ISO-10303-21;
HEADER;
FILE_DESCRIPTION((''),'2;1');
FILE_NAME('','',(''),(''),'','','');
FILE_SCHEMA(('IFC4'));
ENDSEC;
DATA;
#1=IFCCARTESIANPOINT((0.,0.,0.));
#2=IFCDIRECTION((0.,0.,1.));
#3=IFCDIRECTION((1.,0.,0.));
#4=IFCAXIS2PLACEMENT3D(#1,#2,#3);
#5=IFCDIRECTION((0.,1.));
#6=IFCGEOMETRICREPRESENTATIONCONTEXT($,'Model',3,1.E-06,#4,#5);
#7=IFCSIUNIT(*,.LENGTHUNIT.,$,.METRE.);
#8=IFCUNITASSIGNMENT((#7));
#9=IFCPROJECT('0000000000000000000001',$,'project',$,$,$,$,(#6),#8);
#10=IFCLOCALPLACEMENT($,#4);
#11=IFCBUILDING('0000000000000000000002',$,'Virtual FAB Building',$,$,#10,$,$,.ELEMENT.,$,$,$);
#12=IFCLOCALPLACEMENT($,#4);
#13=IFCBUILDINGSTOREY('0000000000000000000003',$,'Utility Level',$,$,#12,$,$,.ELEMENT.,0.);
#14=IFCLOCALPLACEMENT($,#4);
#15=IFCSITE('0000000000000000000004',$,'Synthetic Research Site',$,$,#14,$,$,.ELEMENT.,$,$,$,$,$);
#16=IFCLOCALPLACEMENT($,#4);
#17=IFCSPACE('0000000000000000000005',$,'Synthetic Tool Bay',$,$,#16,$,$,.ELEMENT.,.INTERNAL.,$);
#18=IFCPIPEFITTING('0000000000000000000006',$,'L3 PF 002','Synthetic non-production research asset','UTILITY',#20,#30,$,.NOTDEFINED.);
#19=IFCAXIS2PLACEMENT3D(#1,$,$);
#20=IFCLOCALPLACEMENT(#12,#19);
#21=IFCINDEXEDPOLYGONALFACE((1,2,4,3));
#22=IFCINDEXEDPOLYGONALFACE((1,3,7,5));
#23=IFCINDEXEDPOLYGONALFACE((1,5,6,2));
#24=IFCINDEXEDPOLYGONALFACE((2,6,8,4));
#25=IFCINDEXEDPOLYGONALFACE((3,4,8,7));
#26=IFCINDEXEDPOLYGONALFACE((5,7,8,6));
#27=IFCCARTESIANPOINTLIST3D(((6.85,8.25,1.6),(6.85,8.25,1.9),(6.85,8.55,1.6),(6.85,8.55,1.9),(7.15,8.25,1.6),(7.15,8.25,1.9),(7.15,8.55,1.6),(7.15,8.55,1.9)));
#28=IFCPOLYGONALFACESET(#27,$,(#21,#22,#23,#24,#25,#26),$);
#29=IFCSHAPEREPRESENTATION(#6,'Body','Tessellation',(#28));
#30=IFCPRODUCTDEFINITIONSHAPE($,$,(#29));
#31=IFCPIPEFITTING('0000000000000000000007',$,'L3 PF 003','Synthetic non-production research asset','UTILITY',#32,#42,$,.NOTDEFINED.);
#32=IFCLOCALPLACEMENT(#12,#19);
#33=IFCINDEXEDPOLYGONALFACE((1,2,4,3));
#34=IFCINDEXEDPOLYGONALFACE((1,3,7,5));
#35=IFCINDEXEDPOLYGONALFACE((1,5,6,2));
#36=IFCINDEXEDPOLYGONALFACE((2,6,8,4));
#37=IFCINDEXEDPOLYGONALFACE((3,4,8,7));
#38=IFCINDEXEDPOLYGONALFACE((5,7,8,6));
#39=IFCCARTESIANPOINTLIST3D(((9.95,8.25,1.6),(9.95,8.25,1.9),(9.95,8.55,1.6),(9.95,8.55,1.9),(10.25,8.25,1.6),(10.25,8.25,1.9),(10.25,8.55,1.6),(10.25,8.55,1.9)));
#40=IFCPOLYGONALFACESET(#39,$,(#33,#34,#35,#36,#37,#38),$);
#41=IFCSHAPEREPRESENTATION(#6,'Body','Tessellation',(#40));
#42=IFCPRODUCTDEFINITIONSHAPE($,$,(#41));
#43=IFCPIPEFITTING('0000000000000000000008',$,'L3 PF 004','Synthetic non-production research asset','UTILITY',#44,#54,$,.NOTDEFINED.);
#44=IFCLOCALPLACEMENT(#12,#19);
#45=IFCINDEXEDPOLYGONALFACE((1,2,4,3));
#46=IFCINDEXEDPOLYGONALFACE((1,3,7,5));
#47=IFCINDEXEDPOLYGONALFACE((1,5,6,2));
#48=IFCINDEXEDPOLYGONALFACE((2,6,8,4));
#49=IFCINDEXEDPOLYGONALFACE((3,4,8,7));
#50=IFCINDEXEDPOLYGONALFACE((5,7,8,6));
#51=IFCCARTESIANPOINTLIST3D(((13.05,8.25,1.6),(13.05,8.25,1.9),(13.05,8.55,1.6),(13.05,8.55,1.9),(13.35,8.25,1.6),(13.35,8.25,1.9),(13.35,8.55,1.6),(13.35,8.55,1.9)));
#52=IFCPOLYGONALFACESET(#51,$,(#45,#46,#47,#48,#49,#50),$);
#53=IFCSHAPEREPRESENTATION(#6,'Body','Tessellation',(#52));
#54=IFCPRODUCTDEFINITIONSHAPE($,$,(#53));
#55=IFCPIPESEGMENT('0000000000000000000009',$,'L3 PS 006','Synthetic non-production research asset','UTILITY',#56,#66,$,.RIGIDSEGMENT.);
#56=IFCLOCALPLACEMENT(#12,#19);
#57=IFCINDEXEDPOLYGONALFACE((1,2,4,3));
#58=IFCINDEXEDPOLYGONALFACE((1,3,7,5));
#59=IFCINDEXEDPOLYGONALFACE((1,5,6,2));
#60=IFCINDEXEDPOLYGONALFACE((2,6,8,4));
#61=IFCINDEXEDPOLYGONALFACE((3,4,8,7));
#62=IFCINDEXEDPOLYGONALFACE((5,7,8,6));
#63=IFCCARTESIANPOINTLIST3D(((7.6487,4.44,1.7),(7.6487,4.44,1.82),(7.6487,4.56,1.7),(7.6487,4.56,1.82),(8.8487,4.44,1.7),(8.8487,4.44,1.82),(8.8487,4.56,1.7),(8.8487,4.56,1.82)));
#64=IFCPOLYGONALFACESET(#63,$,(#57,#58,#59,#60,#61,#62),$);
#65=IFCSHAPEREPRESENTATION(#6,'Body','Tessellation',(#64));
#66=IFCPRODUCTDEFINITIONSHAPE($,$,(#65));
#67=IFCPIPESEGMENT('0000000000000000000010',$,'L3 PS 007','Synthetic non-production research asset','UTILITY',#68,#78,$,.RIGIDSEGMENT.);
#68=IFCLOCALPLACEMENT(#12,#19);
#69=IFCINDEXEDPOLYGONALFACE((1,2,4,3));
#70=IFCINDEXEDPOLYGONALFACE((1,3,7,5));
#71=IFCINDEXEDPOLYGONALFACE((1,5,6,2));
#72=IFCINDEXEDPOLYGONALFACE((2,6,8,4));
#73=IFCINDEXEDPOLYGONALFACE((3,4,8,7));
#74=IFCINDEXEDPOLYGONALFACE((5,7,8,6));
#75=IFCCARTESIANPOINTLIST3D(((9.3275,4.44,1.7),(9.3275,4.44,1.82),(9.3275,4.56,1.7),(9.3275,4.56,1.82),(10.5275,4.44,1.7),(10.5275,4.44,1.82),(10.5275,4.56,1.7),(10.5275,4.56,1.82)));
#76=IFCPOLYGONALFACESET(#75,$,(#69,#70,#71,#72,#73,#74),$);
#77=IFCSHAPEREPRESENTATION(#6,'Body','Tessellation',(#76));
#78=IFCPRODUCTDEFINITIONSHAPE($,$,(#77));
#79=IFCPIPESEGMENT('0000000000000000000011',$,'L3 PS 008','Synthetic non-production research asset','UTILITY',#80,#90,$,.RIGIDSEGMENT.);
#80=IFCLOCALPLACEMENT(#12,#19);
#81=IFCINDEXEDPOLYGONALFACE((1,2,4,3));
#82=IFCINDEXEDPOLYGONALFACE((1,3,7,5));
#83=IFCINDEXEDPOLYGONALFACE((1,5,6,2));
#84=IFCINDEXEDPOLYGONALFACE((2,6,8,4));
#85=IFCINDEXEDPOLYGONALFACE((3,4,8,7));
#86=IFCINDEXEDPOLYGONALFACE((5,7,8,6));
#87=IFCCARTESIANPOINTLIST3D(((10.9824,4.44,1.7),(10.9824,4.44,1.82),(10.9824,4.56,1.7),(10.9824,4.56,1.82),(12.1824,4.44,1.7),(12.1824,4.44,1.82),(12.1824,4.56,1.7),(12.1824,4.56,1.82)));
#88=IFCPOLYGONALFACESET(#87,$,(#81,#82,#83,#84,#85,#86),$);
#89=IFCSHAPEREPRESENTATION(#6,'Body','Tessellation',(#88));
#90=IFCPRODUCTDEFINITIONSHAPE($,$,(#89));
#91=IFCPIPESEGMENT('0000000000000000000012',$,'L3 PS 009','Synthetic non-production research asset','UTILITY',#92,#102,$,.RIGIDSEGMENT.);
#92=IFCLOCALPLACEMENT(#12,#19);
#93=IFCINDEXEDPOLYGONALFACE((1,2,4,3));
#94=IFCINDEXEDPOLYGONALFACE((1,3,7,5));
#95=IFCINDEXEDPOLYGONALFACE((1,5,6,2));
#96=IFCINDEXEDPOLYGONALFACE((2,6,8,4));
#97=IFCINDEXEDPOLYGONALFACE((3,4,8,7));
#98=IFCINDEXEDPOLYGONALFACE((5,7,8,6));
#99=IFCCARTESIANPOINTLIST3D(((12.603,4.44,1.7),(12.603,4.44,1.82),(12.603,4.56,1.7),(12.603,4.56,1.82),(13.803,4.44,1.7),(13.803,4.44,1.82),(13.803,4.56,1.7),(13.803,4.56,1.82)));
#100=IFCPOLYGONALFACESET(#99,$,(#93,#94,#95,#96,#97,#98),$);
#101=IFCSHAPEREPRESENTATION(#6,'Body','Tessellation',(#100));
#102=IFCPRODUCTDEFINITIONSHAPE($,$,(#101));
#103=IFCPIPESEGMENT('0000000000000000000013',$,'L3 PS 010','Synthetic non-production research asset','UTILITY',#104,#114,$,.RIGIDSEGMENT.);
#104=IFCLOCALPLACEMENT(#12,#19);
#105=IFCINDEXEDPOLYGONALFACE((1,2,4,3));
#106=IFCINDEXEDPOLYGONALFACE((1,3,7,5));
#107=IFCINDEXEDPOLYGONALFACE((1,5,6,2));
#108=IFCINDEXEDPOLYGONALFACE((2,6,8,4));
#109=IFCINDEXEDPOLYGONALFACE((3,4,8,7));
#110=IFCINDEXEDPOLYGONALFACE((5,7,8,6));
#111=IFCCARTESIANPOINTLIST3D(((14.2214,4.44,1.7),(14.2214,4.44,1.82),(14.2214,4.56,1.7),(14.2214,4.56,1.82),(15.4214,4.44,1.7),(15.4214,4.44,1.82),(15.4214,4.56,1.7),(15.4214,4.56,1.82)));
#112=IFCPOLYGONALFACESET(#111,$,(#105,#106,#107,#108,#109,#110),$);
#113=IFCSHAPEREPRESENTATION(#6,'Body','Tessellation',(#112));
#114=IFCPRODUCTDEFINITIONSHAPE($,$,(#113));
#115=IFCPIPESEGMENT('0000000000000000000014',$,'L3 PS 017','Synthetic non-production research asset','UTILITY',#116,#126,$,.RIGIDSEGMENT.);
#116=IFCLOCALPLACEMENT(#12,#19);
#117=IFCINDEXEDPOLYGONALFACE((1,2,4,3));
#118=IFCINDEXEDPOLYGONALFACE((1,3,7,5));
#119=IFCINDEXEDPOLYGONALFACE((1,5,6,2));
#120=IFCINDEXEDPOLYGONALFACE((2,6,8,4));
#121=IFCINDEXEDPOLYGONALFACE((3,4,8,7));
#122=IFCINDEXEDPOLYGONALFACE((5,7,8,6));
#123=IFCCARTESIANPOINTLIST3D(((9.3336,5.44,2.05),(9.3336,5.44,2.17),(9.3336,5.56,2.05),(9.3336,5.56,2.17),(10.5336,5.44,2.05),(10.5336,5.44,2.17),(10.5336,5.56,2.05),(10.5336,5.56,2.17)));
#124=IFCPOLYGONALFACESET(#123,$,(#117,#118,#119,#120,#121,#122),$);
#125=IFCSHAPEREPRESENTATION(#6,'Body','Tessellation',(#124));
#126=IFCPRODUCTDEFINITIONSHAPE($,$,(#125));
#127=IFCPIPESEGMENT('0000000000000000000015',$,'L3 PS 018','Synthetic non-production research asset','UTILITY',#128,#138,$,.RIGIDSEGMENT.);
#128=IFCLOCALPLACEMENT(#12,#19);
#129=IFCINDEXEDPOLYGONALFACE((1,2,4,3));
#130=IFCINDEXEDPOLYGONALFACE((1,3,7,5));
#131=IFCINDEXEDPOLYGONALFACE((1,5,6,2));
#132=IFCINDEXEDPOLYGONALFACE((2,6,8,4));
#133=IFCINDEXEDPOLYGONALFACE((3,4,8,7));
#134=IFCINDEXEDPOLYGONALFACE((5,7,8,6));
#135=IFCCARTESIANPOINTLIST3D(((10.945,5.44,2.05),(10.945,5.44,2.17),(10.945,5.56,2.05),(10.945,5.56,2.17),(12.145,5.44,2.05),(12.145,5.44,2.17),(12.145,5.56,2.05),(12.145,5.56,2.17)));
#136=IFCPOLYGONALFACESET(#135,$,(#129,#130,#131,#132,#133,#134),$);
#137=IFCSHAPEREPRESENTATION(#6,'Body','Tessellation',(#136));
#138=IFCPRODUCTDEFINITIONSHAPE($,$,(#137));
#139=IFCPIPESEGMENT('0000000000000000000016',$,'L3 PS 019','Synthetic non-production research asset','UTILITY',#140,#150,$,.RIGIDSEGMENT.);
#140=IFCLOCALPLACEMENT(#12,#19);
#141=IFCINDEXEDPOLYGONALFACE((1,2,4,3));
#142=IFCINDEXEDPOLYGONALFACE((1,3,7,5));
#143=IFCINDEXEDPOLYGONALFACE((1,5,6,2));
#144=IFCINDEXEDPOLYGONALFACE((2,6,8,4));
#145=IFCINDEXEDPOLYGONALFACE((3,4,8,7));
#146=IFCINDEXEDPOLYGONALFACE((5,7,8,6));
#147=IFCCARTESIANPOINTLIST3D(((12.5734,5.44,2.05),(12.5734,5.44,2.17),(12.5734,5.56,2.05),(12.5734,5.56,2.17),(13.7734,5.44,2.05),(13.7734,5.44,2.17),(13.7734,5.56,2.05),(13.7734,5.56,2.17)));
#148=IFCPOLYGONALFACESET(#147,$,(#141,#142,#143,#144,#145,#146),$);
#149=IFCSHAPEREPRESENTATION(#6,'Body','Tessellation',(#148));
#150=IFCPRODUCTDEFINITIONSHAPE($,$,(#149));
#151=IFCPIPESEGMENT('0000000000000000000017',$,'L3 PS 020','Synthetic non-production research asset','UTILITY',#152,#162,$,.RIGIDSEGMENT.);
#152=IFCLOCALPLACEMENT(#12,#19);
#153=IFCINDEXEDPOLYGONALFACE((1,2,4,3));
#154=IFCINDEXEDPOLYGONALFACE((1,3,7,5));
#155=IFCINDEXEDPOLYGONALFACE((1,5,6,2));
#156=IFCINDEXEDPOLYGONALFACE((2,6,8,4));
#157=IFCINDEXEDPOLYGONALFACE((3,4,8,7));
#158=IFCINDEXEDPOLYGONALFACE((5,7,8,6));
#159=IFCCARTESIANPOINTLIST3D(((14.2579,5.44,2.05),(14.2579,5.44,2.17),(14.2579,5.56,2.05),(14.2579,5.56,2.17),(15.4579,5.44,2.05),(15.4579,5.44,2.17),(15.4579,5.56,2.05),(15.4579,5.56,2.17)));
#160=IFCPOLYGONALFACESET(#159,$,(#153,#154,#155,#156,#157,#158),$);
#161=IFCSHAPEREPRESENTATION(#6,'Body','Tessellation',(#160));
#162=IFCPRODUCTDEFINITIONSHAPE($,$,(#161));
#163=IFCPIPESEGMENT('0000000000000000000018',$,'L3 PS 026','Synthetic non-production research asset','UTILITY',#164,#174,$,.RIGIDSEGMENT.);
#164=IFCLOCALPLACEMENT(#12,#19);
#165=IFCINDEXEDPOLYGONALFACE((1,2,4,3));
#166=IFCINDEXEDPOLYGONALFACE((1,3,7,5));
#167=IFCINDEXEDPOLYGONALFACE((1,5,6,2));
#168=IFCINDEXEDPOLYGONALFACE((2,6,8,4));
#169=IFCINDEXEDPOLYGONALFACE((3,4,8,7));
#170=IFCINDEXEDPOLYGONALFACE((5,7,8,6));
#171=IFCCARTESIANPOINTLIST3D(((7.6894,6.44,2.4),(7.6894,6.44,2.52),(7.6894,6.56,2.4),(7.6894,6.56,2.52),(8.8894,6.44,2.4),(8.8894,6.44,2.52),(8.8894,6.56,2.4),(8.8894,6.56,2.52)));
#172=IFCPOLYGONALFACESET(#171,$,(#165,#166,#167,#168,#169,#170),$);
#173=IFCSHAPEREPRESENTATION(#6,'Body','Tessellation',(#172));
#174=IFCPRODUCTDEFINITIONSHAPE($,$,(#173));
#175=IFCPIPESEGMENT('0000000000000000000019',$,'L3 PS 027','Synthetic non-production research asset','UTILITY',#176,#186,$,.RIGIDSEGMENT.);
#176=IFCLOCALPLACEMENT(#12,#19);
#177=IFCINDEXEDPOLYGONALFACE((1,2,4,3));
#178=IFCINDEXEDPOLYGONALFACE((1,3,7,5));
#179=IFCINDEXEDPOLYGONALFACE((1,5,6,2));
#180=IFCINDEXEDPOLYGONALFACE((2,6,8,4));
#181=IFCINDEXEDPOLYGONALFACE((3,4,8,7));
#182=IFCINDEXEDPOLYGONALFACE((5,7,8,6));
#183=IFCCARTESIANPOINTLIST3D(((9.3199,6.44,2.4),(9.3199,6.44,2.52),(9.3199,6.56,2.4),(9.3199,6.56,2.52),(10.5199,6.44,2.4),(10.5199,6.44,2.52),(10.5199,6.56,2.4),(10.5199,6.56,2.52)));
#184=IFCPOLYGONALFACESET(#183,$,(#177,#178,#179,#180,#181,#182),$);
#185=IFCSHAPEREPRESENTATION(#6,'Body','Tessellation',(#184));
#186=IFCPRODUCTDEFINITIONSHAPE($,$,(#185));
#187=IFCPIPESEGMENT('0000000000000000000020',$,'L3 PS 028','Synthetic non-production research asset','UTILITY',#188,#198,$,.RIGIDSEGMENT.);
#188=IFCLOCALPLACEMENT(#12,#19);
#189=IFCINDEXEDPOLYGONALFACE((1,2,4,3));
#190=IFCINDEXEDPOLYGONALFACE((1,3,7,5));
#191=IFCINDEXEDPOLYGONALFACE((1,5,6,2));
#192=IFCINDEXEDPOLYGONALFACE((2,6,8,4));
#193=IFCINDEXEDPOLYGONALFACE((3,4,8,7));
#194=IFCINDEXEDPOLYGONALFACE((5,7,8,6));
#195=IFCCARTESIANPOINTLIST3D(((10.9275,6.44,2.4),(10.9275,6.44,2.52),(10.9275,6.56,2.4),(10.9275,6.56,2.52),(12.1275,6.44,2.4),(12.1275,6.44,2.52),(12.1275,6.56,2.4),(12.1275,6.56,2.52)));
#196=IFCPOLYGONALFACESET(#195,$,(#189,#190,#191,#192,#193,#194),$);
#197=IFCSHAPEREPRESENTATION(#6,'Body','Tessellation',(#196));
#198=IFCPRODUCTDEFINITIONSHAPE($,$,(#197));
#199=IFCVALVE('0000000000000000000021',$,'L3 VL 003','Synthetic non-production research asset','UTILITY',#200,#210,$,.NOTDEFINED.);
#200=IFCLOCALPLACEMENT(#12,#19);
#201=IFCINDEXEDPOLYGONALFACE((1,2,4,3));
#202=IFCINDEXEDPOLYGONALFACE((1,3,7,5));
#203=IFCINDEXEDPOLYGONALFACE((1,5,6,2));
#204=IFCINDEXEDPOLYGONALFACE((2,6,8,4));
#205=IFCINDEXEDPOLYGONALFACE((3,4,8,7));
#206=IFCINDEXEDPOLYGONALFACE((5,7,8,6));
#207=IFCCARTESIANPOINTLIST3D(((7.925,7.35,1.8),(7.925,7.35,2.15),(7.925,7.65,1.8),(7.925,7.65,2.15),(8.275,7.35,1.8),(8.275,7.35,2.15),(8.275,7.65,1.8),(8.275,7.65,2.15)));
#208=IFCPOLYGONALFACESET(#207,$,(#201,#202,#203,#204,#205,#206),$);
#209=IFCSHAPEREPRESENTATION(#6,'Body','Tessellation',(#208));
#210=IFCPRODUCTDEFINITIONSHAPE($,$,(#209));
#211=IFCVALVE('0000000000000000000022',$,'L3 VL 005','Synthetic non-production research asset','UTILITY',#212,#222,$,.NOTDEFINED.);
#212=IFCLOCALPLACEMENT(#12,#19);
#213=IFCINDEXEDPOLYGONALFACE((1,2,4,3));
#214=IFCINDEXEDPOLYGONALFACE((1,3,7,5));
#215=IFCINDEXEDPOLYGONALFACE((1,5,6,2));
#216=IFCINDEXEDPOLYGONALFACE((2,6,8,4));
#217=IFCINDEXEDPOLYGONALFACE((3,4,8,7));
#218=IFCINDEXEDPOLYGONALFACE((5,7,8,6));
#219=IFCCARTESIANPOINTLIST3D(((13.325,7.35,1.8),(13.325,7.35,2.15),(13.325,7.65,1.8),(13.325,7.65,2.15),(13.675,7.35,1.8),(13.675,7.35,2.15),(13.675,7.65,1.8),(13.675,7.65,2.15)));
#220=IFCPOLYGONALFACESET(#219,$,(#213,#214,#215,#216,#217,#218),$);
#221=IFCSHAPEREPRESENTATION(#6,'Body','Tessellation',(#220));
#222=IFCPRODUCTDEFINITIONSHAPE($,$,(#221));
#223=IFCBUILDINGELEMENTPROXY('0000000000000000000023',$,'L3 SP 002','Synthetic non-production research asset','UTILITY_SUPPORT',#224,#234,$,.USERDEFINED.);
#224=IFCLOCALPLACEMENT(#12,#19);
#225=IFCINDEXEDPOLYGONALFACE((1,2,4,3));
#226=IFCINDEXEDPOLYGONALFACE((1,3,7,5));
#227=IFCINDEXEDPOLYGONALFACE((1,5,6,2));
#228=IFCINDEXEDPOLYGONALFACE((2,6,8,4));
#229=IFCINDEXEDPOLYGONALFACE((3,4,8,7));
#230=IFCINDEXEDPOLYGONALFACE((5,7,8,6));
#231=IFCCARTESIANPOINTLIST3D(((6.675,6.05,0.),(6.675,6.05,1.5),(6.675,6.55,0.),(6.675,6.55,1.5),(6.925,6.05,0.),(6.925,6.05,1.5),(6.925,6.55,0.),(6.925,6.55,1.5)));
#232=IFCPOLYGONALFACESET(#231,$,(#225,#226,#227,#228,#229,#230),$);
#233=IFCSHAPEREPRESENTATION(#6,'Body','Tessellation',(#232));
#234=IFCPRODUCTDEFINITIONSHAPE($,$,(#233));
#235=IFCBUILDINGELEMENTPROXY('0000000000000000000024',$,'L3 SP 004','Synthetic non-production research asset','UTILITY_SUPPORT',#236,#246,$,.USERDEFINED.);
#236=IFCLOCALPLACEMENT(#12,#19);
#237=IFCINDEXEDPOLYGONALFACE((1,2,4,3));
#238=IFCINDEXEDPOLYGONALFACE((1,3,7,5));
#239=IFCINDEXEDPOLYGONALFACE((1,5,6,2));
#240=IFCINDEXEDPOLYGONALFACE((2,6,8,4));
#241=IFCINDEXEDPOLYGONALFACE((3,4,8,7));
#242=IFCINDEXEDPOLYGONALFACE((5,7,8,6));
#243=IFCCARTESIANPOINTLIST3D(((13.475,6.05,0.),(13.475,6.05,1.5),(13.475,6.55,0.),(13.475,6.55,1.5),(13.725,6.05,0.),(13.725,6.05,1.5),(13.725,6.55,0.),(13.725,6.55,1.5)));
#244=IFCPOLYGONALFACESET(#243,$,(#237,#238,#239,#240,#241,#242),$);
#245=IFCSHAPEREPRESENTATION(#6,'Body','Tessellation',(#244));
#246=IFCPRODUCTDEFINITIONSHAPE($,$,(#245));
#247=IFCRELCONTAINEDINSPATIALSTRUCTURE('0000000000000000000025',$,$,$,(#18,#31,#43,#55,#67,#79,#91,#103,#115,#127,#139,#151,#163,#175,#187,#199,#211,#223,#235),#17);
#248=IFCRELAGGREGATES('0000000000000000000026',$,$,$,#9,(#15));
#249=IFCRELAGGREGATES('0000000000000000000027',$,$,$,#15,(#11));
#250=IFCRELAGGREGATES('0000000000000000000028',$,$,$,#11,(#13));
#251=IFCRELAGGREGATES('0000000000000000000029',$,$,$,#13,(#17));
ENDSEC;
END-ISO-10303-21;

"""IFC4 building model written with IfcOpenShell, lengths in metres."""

from ifc_helpers import new_model, si_unit, direction, frame, origin_with_axes, origin_2d_with_axis, place, context, project, spatial, rectangle, extrude, element, save


model = new_model("IFC4")

# Units and contexts
model_context = context("Model", 3, precision=1e-06, world=origin_with_axes(), true_north=direction((0.0, 1.0)))
ifc_project = project(units=[si_unit("LENGTHUNIT", "METRE")], contexts=[model_context])

# Site, building, storey, space
site_placement = place(None, origin_with_axes())
site = spatial("IfcSite", under=ifc_project, at=site_placement, Name="Synthetic Research Site", CompositionType="ELEMENT")
building_placement = place(None, origin_with_axes())
building = spatial("IfcBuilding", under=site, at=building_placement, Name="Virtual FAB Building", CompositionType="ELEMENT")
storey_placement = place(None, origin_with_axes())
storey = spatial("IfcBuildingStorey", under=building, at=storey_placement, Name="Utility Level", CompositionType="ELEMENT", Elevation=0.0)
space_placement = place(None, origin_with_axes())
space = spatial("IfcSpace", under=storey, at=space_placement, Name="Synthetic Tool Bay", CompositionType="ELEMENT", PredefinedType="INTERNAL")

# Pipe fittings
for number, where, z_axis, x_axis, name in (
    (1, (7.0, 8.4, 1.6), (0.0, 0.0, 1.0), (1.0, 0.0, 0.0), "L3 PF 002"),
    (2, (10.1, 8.4, 1.6), (0.0, 0.0, 1.0), (1.0, 0.0, 0.0), "L3 PF 003"),
    (3, (13.2, 8.4, 1.6), (0.0, 0.0, 1.0), (1.0, 0.0, 0.0), "L3 PF 004"),
):
    element("IfcPipeFitting", number, at=place(None, frame(where, z_axis=z_axis, x_axis=x_axis)), inside=space, Name=name, Description="Synthetic non-production research asset", ObjectType="UTILITY", PredefinedType="NOTDEFINED", context=model_context, shape_type="SweptSolid", body=[
        extrude(rectangle(XDim=0.3, YDim=0.3, at=origin_2d_with_axis()), origin_with_axes(), (0.0, 0.0, 1.0), 0.3),
    ])

# Pipe segments
for number, where, z_axis, x_axis, name in (
    (4, (8.2487, 4.5, 1.7), (0.0, 0.0, 1.0), (1.0, 0.0, 0.0), "L3 PS 006"),
    (5, (9.9275, 4.5, 1.7), (0.0, 0.0, 1.0), (1.0, 0.0, 0.0), "L3 PS 007"),
    (6, (11.5824, 4.5, 1.7), (0.0, 0.0, 1.0), (1.0, 0.0, 0.0), "L3 PS 008"),
    (7, (13.203, 4.5, 1.7), (0.0, 0.0, 1.0), (1.0, 0.0, 0.0), "L3 PS 009"),
    (8, (14.8214, 4.5, 1.7), (0.0, 0.0, 1.0), (1.0, 0.0, 0.0), "L3 PS 010"),
    (9, (9.9336, 5.5, 2.05), (0.0, 0.0, 1.0), (1.0, 0.0, 0.0), "L3 PS 017"),
    (10, (11.545, 5.5, 2.05), (0.0, 0.0, 1.0), (1.0, 0.0, 0.0), "L3 PS 018"),
    (11, (13.1734, 5.5, 2.05), (0.0, 0.0, 1.0), (1.0, 0.0, 0.0), "L3 PS 019"),
    (12, (14.8579, 5.5, 2.05), (0.0, 0.0, 1.0), (1.0, 0.0, 0.0), "L3 PS 020"),
    (13, (8.2894, 6.5, 2.4), (0.0, 0.0, 1.0), (1.0, 0.0, 0.0), "L3 PS 026"),
    (14, (9.9199, 6.5, 2.4), (0.0, 0.0, 1.0), (1.0, 0.0, 0.0), "L3 PS 027"),
    (15, (11.5275, 6.5, 2.4), (0.0, 0.0, 1.0), (1.0, 0.0, 0.0), "L3 PS 028"),
):
    element("IfcPipeSegment", number, at=place(None, frame(where, z_axis=z_axis, x_axis=x_axis)), inside=space, Name=name, Description="Synthetic non-production research asset", ObjectType="UTILITY", PredefinedType="RIGIDSEGMENT", context=model_context, shape_type="SweptSolid", body=[
        extrude(rectangle(XDim=1.2, YDim=0.12, at=origin_2d_with_axis()), origin_with_axes(), (0.0, 0.0, 1.0), 0.12),
    ])

# Valves
for number, where, z_axis, x_axis, name in (
    (16, (8.1, 7.5, 1.8), (0.0, 0.0, 1.0), (1.0, 0.0, 0.0), "L3 VL 003"),
    (17, (13.5, 7.5, 1.8), (0.0, 0.0, 1.0), (1.0, 0.0, 0.0), "L3 VL 005"),
):
    element("IfcValve", number, at=place(None, frame(where, z_axis=z_axis, x_axis=x_axis)), inside=space, Name=name, Description="Synthetic non-production research asset", ObjectType="UTILITY", PredefinedType="NOTDEFINED", context=model_context, shape_type="SweptSolid", body=[
        extrude(rectangle(XDim=0.35, YDim=0.3, at=origin_2d_with_axis()), origin_with_axes(), (0.0, 0.0, 1.0), 0.35),
    ])

# Building element proxies
for number, where, z_axis, x_axis, name in (
    (18, (6.8, 6.3, 0.0), (0.0, 0.0, 1.0), (1.0, 0.0, 0.0), "L3 SP 002"),
    (19, (13.6, 6.3, 0.0), (0.0, 0.0, 1.0), (1.0, 0.0, 0.0), "L3 SP 004"),
):
    element("IfcBuildingElementProxy", number, at=place(None, frame(where, z_axis=z_axis, x_axis=x_axis)), inside=space, Name=name, Description="Synthetic non-production research asset", ObjectType="UTILITY_SUPPORT", PredefinedType="USERDEFINED", context=model_context, shape_type="SweptSolid", body=[
        extrude(rectangle(XDim=0.25, YDim=0.5, at=origin_2d_with_axis()), origin_with_axes(), (0.0, 0.0, 1.0), 1.5),
    ])

save(model, "model.ifc")
